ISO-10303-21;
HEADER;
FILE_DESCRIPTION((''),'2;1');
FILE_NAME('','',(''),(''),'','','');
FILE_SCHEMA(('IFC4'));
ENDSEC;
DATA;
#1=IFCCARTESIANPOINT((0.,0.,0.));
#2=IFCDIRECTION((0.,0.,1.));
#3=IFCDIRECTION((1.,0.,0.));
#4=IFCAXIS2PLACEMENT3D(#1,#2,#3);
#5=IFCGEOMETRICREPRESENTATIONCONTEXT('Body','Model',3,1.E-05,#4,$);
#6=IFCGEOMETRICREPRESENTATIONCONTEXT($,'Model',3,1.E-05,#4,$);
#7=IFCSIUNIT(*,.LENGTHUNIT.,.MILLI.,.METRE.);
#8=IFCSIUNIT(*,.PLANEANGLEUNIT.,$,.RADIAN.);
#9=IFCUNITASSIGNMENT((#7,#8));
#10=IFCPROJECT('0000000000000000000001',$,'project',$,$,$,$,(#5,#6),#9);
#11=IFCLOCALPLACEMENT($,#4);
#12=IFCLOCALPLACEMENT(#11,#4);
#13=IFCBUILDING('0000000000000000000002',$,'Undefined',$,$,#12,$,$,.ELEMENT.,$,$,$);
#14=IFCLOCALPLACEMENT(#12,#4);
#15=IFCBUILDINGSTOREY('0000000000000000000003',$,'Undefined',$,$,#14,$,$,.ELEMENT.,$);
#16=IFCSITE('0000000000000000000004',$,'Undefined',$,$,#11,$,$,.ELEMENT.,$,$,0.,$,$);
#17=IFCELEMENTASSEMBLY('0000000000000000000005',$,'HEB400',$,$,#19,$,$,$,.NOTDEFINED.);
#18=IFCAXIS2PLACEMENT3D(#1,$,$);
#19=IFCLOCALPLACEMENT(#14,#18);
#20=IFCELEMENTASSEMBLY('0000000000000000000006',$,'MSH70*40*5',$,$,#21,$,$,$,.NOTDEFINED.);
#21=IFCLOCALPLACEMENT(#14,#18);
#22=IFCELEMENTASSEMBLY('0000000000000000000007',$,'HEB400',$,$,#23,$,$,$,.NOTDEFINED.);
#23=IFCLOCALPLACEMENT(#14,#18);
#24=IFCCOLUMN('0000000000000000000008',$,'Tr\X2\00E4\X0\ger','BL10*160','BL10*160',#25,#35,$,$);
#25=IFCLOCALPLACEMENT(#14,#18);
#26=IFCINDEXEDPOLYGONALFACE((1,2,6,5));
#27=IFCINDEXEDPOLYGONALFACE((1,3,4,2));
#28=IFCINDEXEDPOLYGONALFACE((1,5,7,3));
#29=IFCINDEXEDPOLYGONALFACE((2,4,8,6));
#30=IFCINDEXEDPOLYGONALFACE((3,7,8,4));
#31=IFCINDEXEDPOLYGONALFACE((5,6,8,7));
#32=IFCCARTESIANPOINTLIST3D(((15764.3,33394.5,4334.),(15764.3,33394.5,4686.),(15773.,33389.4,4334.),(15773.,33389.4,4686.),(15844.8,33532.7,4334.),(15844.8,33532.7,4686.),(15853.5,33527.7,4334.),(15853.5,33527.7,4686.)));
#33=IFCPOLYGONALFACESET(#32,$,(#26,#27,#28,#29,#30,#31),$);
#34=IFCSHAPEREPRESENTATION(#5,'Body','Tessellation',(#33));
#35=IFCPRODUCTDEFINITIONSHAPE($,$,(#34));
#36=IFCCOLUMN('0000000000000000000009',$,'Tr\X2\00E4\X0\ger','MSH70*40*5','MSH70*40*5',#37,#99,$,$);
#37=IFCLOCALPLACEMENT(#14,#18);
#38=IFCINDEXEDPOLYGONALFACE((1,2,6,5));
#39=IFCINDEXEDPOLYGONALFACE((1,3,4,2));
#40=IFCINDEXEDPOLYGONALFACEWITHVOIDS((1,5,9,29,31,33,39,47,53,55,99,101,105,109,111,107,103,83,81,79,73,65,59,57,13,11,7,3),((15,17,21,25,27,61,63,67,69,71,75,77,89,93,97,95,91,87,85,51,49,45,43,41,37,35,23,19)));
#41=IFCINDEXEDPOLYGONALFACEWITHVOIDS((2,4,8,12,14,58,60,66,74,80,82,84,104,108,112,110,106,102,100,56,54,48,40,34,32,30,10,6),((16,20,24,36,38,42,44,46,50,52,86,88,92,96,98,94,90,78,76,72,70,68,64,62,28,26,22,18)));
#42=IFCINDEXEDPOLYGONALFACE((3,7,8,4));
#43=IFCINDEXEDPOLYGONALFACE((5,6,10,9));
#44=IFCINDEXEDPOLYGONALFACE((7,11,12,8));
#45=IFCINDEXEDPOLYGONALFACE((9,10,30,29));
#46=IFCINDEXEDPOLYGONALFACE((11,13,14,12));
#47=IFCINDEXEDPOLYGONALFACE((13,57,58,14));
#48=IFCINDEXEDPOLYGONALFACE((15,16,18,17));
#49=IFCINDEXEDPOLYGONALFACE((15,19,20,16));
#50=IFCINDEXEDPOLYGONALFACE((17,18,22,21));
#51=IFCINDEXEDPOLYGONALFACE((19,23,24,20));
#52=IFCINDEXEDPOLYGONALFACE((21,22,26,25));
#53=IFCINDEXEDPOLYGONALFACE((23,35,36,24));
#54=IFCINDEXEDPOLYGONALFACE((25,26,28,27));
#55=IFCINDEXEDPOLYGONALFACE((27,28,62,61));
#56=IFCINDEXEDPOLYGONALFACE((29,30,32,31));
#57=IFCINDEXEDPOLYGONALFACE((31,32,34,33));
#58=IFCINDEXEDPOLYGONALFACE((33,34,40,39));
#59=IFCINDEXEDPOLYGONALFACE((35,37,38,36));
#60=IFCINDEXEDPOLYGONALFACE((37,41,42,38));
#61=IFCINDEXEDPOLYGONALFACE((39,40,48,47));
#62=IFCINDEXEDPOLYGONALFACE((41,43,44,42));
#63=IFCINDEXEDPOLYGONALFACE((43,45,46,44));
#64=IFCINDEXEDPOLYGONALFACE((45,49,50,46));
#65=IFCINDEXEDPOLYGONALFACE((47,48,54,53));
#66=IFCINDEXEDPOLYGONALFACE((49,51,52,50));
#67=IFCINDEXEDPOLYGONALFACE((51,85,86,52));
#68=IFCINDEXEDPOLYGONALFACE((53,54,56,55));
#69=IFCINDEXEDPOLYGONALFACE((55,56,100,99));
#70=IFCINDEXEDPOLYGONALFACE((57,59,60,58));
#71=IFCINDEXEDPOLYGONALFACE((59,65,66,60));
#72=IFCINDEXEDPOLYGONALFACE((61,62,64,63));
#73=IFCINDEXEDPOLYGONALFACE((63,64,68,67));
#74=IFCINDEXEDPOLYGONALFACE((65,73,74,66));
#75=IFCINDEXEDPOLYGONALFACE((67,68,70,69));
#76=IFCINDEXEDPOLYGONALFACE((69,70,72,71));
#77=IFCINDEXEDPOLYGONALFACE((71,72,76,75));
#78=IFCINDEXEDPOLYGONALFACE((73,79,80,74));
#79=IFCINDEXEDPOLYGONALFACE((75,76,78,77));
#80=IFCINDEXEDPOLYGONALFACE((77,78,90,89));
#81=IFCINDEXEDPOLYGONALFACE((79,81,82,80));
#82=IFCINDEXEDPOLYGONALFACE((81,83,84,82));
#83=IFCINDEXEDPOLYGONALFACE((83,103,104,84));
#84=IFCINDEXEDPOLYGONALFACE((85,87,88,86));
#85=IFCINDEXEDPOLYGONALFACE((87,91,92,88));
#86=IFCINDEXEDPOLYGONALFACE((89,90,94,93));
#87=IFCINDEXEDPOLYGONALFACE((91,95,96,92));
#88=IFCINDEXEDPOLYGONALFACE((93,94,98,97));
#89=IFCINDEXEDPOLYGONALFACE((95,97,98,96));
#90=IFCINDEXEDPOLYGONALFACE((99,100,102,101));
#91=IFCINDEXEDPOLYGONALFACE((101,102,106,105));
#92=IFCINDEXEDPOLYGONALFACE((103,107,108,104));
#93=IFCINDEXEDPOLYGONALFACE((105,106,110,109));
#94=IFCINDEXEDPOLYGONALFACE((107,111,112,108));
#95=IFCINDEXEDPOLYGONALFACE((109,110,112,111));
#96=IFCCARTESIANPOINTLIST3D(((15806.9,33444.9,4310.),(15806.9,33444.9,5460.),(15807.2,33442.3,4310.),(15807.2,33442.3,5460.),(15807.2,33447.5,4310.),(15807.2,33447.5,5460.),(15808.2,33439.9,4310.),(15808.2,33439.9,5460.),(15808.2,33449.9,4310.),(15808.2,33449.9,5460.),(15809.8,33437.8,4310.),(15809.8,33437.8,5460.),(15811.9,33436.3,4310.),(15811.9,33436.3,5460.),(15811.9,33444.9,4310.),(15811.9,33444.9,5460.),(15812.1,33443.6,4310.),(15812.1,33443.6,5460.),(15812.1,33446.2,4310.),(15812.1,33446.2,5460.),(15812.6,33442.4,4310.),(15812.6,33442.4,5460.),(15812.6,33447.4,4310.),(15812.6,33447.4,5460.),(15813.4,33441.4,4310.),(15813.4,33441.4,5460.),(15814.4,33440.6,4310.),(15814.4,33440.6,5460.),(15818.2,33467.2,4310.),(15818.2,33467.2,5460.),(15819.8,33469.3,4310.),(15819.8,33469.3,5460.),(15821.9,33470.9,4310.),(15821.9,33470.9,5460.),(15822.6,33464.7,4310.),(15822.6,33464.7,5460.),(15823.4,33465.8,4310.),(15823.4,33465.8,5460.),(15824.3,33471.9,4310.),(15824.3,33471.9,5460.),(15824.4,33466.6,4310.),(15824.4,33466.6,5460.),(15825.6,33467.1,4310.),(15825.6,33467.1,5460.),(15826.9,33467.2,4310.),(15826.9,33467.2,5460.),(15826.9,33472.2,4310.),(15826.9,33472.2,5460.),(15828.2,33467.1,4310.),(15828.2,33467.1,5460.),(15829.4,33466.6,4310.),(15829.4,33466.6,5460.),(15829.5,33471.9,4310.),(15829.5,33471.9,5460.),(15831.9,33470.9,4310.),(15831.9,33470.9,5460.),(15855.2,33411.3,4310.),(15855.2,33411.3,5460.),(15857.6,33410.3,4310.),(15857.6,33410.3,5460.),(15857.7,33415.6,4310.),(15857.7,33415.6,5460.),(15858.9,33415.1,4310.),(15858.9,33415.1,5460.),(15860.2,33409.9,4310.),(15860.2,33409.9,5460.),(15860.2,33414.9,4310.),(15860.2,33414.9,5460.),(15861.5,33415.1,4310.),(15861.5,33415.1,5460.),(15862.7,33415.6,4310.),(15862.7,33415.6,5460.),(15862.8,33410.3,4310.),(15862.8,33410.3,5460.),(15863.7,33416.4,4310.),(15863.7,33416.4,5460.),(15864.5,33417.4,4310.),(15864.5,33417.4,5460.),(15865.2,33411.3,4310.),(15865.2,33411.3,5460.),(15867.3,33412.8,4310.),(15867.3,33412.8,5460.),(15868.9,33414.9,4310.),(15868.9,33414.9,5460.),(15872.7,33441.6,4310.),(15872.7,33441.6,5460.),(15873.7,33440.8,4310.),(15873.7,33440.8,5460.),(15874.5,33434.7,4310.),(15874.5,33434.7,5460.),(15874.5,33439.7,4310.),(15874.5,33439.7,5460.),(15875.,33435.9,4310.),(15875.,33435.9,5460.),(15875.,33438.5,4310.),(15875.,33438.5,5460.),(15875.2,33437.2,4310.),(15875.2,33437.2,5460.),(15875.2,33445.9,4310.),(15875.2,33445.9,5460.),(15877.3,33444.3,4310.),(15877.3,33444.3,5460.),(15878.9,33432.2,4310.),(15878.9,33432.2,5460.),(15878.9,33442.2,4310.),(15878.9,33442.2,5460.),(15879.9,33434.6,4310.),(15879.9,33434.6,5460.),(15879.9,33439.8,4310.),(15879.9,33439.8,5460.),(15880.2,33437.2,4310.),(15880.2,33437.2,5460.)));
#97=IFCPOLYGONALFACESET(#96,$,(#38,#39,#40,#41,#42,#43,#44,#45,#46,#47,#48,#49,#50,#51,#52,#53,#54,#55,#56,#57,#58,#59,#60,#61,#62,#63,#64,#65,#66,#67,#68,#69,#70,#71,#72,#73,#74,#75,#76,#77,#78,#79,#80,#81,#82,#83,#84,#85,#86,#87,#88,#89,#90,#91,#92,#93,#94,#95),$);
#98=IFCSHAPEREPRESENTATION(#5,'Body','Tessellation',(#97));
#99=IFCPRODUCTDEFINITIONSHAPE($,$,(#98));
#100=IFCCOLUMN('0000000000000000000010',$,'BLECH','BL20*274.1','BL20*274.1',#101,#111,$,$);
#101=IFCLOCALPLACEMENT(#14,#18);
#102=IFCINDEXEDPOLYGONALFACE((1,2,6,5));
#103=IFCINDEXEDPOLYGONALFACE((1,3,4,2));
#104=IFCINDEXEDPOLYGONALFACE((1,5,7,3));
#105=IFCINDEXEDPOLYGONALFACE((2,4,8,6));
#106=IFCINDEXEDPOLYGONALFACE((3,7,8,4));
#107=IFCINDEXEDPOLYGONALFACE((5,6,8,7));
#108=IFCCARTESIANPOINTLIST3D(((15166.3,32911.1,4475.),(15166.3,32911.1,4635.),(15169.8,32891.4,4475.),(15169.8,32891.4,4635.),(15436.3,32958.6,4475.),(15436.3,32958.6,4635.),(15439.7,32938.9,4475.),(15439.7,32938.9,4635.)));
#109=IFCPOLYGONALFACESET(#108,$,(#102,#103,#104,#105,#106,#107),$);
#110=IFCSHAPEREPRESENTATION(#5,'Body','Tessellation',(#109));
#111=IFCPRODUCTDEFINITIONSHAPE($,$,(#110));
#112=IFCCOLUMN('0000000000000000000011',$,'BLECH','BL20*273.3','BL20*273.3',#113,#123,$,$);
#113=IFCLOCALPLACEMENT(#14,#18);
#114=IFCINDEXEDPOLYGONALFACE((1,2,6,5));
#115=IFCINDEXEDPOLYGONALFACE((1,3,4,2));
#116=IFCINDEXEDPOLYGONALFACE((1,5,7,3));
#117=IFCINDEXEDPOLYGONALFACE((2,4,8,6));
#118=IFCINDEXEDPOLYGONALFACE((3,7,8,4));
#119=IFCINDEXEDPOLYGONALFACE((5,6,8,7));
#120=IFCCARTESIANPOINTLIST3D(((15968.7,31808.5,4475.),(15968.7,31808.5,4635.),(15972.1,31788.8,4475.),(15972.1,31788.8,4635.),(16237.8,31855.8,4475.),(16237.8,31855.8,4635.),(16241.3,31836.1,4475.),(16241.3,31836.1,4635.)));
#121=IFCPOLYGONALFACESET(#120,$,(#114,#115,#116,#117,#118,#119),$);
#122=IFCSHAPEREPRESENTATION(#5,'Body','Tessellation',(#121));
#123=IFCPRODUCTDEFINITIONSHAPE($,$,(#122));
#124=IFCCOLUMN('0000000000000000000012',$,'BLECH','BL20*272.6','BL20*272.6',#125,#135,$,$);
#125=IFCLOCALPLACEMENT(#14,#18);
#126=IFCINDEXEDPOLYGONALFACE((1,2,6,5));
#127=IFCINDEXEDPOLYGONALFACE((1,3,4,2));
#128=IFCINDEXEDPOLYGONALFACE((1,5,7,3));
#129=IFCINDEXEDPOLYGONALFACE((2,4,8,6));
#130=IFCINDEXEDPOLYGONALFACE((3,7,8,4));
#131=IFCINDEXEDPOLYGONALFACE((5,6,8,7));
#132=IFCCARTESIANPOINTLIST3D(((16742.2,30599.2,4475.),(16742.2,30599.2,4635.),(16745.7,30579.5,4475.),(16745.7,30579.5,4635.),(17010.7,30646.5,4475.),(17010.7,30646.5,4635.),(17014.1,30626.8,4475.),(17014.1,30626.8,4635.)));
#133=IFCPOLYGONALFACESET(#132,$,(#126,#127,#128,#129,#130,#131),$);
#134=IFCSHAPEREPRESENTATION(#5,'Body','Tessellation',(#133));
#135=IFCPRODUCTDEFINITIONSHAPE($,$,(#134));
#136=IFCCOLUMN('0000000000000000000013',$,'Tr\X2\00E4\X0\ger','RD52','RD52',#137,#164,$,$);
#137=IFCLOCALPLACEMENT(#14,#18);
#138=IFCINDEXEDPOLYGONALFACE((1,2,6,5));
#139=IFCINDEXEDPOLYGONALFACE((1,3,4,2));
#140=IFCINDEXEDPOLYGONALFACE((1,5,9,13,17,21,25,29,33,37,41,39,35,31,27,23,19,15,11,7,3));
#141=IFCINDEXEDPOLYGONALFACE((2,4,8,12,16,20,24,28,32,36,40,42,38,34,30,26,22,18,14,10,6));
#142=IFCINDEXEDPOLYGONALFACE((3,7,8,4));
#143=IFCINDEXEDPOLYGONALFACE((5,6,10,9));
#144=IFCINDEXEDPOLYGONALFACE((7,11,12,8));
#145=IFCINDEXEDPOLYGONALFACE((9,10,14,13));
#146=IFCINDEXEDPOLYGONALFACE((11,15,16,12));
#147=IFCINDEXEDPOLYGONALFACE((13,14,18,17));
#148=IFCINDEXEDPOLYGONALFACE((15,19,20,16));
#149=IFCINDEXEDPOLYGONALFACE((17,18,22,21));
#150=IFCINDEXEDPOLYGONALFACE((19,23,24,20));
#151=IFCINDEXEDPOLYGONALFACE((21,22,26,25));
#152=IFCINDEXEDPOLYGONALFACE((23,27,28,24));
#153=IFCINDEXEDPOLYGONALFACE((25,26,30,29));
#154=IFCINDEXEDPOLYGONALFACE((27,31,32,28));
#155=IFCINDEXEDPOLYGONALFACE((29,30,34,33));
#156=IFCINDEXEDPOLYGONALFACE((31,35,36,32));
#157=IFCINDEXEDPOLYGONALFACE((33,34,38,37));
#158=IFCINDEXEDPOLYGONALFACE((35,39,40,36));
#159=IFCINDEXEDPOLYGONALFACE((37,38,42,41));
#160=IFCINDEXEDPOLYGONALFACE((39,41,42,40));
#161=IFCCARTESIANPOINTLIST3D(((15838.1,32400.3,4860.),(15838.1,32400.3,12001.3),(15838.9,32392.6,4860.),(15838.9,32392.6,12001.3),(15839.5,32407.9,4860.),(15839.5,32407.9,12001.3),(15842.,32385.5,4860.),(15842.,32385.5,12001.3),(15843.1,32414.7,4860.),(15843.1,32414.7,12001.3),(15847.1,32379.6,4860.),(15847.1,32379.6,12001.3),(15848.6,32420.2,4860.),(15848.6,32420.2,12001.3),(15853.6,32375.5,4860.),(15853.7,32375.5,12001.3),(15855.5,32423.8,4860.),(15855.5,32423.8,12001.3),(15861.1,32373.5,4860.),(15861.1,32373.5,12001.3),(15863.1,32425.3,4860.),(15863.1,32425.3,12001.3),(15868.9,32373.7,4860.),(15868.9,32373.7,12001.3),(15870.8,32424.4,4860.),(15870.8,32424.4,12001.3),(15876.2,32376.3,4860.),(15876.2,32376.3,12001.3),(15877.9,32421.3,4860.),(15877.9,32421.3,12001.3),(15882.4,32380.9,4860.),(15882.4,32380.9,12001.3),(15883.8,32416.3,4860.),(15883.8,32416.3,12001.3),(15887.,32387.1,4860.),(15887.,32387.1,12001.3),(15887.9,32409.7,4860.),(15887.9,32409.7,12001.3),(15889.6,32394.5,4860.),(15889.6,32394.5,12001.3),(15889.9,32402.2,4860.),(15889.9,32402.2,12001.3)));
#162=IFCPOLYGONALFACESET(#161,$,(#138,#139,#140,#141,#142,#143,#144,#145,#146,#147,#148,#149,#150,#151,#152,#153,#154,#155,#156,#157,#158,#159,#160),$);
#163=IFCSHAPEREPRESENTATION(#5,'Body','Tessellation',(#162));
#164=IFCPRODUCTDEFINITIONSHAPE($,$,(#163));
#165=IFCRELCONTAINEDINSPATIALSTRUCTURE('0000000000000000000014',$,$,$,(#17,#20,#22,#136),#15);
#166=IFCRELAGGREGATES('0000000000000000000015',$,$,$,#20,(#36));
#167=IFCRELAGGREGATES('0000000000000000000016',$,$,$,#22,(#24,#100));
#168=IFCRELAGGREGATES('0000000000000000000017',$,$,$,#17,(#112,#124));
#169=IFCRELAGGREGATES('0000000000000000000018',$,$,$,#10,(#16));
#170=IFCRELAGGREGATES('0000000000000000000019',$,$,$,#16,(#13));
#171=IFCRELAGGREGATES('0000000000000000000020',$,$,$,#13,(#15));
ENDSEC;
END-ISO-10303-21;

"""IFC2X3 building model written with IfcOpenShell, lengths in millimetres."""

from ifc_helpers import new_model, si_unit, frame, origin_with_axes, origin_2d_with_axis, place, context, project, spatial, rectangle, hollow_rectangle, circle, extrude, element, aggregate, save


model = new_model("IFC2X3")

# Units and contexts
model_context_1 = context("Model", 3, precision=1e-05, world=origin_with_axes(), identifier="Body")
model_context_2 = context("Model", 3, precision=1e-05, world=origin_with_axes())
ifc_project = project(units=[si_unit("LENGTHUNIT", "METRE", prefix="MILLI"), si_unit("PLANEANGLEUNIT", "RADIAN")], contexts=[model_context_1, model_context_2])

# Site, building, storey
site_placement = place(None, origin_with_axes())
site = spatial("IfcSite", under=ifc_project, at=site_placement, Name="Undefined", CompositionType="ELEMENT", RefElevation=0.0)
building_placement = place(site_placement, origin_with_axes())
building = spatial("IfcBuilding", under=site, at=building_placement, Name="Undefined", CompositionType="ELEMENT")
storey_placement = place(building_placement, origin_with_axes())
storey = spatial("IfcBuildingStorey", under=building, at=storey_placement, Name="Undefined", CompositionType="ELEMENT")

# Element assembly
assembly_1 = element("IfcElementAssembly", 1, inside=storey, Name="HEB400", PredefinedType="NOTDEFINED")

# Element assembly
assembly_2 = element("IfcElementAssembly", 2, inside=storey, Name="MSH70*40*5", PredefinedType="NOTDEFINED")

# Element assembly, column
assembly_3 = element("IfcElementAssembly", 3, inside=storey, Name="HEB400", PredefinedType="NOTDEFINED")
column_1_placement = place(storey_placement, frame((15808.9, 33461.1, 4334.0), z_axis=(0.0, 0.0, 1.0), x_axis=(1.0, 0.0, 0.0)))
column_1 = element("IfcColumn", 4, at=column_1_placement, Name="Träger", Description="BL10*160", ObjectType="BL10*160", context=model_context_1, shape_type="SweptSolid", body=[
    extrude(rectangle(XDim=10.0, YDim=160.0, at=origin_2d_with_axis()), frame((0.0, 0.0, 352.0), z_axis=(0.0, 0.0, -1.0), x_axis=(0.864275, -0.50302, 0.0)), (0.0, 0.0, 1.0), 352.0),
])

# Columns
column_2_placement = place(storey_placement, frame((15843.5, 33441.1, 4310.0), z_axis=(0.0, 0.0, 1.0), x_axis=(1.0, 0.0, 0.0)))
column_2 = element("IfcColumn", 5, at=column_2_placement, Name="Träger", Description="MSH70*40*5", ObjectType="MSH70*40*5", context=model_context_1, shape_type="SweptSolid", body=[
    extrude(hollow_rectangle(XDim=40.0, YDim=70.0, WallThickness=5.0, InnerFilletRadius=5.0, OuterFilletRadius=10.0, at=origin_2d_with_axis()), frame((0.0, 0.0, 1150.0), z_axis=(0.0, 0.0, -1.0), x_axis=(0.5, 0.866025, 0.0)), (0.0, 0.0, 1.0), 1150.0),
])
aggregate(assembly_2, [column_2])
column_3_placement = place(storey_placement, frame((15303.0, 32925.0, 4475.0), z_axis=(0.0, 0.0, 1.0), x_axis=(1.0, 0.0, 0.0)))
column_3 = element("IfcColumn", 6, at=column_3_placement, Name="BLECH", Description="BL20*274.1", ObjectType="BL20*274.1", context=model_context_1, shape_type="SweptSolid", body=[
    extrude(rectangle(XDim=20.0, YDim=274.1, at=origin_2d_with_axis()), frame((0.0, 0.0, 160.0), z_axis=(0.0, 0.0, -1.0), x_axis=(-0.173304, 0.984868, 0.0)), (0.0, 0.0, 1.0), 160.0),
])
aggregate(assembly_3, [column_1, column_3])
column_4_placement = place(storey_placement, frame((16105.0, 31822.3, 4475.0), z_axis=(0.0, 0.0, 1.0), x_axis=(1.0, 0.0, 0.0)))
column_4 = element("IfcColumn", 7, at=column_4_placement, Name="BLECH", Description="BL20*273.3", ObjectType="BL20*273.3", context=model_context_1, shape_type="SweptSolid", body=[
    extrude(rectangle(XDim=20.0, YDim=273.3, at=origin_2d_with_axis()), frame((0.0, 0.0, 160.0), z_axis=(0.0, 0.0, -1.0), x_axis=(-0.173304, 0.984868, 0.0)), (0.0, 0.0, 1.0), 160.0),
])
column_5_placement = place(storey_placement, frame((16878.2, 30613.0, 4475.0), z_axis=(0.0, 0.0, 1.0), x_axis=(1.0, 0.0, 0.0)))
column_5 = element("IfcColumn", 8, at=column_5_placement, Name="BLECH", Description="BL20*272.6", ObjectType="BL20*272.6", context=model_context_1, shape_type="SweptSolid", body=[
    extrude(rectangle(XDim=20.0, YDim=272.6, at=origin_2d_with_axis()), frame((0.0, 0.0, 160.0), z_axis=(0.0, 0.0, -1.0), x_axis=(-0.173304, 0.984868, 0.0)), (0.0, 0.0, 1.0), 160.0),
])
aggregate(assembly_1, [column_4, column_5])
column_6_placement = place(storey_placement, frame((15864.0, 32399.3, 4860.0), z_axis=(0.0, 0.0, 1.0), x_axis=(1.0, 0.0, 0.0)))
element("IfcColumn", 9, at=column_6_placement, inside=storey, Name="Träger", Description="RD52", ObjectType="RD52", context=model_context_1, shape_type="SweptSolid", body=[
    extrude(circle(Radius=26.0, at=origin_2d_with_axis()), frame((0.0, 0.0, 7141.3), z_axis=(0.0, 0.0, -1.0), x_axis=(0.707105, -0.707108, 0.0)), (0.0, 0.0, 1.0), 7141.3),
])

save(model, "model.ifc")
